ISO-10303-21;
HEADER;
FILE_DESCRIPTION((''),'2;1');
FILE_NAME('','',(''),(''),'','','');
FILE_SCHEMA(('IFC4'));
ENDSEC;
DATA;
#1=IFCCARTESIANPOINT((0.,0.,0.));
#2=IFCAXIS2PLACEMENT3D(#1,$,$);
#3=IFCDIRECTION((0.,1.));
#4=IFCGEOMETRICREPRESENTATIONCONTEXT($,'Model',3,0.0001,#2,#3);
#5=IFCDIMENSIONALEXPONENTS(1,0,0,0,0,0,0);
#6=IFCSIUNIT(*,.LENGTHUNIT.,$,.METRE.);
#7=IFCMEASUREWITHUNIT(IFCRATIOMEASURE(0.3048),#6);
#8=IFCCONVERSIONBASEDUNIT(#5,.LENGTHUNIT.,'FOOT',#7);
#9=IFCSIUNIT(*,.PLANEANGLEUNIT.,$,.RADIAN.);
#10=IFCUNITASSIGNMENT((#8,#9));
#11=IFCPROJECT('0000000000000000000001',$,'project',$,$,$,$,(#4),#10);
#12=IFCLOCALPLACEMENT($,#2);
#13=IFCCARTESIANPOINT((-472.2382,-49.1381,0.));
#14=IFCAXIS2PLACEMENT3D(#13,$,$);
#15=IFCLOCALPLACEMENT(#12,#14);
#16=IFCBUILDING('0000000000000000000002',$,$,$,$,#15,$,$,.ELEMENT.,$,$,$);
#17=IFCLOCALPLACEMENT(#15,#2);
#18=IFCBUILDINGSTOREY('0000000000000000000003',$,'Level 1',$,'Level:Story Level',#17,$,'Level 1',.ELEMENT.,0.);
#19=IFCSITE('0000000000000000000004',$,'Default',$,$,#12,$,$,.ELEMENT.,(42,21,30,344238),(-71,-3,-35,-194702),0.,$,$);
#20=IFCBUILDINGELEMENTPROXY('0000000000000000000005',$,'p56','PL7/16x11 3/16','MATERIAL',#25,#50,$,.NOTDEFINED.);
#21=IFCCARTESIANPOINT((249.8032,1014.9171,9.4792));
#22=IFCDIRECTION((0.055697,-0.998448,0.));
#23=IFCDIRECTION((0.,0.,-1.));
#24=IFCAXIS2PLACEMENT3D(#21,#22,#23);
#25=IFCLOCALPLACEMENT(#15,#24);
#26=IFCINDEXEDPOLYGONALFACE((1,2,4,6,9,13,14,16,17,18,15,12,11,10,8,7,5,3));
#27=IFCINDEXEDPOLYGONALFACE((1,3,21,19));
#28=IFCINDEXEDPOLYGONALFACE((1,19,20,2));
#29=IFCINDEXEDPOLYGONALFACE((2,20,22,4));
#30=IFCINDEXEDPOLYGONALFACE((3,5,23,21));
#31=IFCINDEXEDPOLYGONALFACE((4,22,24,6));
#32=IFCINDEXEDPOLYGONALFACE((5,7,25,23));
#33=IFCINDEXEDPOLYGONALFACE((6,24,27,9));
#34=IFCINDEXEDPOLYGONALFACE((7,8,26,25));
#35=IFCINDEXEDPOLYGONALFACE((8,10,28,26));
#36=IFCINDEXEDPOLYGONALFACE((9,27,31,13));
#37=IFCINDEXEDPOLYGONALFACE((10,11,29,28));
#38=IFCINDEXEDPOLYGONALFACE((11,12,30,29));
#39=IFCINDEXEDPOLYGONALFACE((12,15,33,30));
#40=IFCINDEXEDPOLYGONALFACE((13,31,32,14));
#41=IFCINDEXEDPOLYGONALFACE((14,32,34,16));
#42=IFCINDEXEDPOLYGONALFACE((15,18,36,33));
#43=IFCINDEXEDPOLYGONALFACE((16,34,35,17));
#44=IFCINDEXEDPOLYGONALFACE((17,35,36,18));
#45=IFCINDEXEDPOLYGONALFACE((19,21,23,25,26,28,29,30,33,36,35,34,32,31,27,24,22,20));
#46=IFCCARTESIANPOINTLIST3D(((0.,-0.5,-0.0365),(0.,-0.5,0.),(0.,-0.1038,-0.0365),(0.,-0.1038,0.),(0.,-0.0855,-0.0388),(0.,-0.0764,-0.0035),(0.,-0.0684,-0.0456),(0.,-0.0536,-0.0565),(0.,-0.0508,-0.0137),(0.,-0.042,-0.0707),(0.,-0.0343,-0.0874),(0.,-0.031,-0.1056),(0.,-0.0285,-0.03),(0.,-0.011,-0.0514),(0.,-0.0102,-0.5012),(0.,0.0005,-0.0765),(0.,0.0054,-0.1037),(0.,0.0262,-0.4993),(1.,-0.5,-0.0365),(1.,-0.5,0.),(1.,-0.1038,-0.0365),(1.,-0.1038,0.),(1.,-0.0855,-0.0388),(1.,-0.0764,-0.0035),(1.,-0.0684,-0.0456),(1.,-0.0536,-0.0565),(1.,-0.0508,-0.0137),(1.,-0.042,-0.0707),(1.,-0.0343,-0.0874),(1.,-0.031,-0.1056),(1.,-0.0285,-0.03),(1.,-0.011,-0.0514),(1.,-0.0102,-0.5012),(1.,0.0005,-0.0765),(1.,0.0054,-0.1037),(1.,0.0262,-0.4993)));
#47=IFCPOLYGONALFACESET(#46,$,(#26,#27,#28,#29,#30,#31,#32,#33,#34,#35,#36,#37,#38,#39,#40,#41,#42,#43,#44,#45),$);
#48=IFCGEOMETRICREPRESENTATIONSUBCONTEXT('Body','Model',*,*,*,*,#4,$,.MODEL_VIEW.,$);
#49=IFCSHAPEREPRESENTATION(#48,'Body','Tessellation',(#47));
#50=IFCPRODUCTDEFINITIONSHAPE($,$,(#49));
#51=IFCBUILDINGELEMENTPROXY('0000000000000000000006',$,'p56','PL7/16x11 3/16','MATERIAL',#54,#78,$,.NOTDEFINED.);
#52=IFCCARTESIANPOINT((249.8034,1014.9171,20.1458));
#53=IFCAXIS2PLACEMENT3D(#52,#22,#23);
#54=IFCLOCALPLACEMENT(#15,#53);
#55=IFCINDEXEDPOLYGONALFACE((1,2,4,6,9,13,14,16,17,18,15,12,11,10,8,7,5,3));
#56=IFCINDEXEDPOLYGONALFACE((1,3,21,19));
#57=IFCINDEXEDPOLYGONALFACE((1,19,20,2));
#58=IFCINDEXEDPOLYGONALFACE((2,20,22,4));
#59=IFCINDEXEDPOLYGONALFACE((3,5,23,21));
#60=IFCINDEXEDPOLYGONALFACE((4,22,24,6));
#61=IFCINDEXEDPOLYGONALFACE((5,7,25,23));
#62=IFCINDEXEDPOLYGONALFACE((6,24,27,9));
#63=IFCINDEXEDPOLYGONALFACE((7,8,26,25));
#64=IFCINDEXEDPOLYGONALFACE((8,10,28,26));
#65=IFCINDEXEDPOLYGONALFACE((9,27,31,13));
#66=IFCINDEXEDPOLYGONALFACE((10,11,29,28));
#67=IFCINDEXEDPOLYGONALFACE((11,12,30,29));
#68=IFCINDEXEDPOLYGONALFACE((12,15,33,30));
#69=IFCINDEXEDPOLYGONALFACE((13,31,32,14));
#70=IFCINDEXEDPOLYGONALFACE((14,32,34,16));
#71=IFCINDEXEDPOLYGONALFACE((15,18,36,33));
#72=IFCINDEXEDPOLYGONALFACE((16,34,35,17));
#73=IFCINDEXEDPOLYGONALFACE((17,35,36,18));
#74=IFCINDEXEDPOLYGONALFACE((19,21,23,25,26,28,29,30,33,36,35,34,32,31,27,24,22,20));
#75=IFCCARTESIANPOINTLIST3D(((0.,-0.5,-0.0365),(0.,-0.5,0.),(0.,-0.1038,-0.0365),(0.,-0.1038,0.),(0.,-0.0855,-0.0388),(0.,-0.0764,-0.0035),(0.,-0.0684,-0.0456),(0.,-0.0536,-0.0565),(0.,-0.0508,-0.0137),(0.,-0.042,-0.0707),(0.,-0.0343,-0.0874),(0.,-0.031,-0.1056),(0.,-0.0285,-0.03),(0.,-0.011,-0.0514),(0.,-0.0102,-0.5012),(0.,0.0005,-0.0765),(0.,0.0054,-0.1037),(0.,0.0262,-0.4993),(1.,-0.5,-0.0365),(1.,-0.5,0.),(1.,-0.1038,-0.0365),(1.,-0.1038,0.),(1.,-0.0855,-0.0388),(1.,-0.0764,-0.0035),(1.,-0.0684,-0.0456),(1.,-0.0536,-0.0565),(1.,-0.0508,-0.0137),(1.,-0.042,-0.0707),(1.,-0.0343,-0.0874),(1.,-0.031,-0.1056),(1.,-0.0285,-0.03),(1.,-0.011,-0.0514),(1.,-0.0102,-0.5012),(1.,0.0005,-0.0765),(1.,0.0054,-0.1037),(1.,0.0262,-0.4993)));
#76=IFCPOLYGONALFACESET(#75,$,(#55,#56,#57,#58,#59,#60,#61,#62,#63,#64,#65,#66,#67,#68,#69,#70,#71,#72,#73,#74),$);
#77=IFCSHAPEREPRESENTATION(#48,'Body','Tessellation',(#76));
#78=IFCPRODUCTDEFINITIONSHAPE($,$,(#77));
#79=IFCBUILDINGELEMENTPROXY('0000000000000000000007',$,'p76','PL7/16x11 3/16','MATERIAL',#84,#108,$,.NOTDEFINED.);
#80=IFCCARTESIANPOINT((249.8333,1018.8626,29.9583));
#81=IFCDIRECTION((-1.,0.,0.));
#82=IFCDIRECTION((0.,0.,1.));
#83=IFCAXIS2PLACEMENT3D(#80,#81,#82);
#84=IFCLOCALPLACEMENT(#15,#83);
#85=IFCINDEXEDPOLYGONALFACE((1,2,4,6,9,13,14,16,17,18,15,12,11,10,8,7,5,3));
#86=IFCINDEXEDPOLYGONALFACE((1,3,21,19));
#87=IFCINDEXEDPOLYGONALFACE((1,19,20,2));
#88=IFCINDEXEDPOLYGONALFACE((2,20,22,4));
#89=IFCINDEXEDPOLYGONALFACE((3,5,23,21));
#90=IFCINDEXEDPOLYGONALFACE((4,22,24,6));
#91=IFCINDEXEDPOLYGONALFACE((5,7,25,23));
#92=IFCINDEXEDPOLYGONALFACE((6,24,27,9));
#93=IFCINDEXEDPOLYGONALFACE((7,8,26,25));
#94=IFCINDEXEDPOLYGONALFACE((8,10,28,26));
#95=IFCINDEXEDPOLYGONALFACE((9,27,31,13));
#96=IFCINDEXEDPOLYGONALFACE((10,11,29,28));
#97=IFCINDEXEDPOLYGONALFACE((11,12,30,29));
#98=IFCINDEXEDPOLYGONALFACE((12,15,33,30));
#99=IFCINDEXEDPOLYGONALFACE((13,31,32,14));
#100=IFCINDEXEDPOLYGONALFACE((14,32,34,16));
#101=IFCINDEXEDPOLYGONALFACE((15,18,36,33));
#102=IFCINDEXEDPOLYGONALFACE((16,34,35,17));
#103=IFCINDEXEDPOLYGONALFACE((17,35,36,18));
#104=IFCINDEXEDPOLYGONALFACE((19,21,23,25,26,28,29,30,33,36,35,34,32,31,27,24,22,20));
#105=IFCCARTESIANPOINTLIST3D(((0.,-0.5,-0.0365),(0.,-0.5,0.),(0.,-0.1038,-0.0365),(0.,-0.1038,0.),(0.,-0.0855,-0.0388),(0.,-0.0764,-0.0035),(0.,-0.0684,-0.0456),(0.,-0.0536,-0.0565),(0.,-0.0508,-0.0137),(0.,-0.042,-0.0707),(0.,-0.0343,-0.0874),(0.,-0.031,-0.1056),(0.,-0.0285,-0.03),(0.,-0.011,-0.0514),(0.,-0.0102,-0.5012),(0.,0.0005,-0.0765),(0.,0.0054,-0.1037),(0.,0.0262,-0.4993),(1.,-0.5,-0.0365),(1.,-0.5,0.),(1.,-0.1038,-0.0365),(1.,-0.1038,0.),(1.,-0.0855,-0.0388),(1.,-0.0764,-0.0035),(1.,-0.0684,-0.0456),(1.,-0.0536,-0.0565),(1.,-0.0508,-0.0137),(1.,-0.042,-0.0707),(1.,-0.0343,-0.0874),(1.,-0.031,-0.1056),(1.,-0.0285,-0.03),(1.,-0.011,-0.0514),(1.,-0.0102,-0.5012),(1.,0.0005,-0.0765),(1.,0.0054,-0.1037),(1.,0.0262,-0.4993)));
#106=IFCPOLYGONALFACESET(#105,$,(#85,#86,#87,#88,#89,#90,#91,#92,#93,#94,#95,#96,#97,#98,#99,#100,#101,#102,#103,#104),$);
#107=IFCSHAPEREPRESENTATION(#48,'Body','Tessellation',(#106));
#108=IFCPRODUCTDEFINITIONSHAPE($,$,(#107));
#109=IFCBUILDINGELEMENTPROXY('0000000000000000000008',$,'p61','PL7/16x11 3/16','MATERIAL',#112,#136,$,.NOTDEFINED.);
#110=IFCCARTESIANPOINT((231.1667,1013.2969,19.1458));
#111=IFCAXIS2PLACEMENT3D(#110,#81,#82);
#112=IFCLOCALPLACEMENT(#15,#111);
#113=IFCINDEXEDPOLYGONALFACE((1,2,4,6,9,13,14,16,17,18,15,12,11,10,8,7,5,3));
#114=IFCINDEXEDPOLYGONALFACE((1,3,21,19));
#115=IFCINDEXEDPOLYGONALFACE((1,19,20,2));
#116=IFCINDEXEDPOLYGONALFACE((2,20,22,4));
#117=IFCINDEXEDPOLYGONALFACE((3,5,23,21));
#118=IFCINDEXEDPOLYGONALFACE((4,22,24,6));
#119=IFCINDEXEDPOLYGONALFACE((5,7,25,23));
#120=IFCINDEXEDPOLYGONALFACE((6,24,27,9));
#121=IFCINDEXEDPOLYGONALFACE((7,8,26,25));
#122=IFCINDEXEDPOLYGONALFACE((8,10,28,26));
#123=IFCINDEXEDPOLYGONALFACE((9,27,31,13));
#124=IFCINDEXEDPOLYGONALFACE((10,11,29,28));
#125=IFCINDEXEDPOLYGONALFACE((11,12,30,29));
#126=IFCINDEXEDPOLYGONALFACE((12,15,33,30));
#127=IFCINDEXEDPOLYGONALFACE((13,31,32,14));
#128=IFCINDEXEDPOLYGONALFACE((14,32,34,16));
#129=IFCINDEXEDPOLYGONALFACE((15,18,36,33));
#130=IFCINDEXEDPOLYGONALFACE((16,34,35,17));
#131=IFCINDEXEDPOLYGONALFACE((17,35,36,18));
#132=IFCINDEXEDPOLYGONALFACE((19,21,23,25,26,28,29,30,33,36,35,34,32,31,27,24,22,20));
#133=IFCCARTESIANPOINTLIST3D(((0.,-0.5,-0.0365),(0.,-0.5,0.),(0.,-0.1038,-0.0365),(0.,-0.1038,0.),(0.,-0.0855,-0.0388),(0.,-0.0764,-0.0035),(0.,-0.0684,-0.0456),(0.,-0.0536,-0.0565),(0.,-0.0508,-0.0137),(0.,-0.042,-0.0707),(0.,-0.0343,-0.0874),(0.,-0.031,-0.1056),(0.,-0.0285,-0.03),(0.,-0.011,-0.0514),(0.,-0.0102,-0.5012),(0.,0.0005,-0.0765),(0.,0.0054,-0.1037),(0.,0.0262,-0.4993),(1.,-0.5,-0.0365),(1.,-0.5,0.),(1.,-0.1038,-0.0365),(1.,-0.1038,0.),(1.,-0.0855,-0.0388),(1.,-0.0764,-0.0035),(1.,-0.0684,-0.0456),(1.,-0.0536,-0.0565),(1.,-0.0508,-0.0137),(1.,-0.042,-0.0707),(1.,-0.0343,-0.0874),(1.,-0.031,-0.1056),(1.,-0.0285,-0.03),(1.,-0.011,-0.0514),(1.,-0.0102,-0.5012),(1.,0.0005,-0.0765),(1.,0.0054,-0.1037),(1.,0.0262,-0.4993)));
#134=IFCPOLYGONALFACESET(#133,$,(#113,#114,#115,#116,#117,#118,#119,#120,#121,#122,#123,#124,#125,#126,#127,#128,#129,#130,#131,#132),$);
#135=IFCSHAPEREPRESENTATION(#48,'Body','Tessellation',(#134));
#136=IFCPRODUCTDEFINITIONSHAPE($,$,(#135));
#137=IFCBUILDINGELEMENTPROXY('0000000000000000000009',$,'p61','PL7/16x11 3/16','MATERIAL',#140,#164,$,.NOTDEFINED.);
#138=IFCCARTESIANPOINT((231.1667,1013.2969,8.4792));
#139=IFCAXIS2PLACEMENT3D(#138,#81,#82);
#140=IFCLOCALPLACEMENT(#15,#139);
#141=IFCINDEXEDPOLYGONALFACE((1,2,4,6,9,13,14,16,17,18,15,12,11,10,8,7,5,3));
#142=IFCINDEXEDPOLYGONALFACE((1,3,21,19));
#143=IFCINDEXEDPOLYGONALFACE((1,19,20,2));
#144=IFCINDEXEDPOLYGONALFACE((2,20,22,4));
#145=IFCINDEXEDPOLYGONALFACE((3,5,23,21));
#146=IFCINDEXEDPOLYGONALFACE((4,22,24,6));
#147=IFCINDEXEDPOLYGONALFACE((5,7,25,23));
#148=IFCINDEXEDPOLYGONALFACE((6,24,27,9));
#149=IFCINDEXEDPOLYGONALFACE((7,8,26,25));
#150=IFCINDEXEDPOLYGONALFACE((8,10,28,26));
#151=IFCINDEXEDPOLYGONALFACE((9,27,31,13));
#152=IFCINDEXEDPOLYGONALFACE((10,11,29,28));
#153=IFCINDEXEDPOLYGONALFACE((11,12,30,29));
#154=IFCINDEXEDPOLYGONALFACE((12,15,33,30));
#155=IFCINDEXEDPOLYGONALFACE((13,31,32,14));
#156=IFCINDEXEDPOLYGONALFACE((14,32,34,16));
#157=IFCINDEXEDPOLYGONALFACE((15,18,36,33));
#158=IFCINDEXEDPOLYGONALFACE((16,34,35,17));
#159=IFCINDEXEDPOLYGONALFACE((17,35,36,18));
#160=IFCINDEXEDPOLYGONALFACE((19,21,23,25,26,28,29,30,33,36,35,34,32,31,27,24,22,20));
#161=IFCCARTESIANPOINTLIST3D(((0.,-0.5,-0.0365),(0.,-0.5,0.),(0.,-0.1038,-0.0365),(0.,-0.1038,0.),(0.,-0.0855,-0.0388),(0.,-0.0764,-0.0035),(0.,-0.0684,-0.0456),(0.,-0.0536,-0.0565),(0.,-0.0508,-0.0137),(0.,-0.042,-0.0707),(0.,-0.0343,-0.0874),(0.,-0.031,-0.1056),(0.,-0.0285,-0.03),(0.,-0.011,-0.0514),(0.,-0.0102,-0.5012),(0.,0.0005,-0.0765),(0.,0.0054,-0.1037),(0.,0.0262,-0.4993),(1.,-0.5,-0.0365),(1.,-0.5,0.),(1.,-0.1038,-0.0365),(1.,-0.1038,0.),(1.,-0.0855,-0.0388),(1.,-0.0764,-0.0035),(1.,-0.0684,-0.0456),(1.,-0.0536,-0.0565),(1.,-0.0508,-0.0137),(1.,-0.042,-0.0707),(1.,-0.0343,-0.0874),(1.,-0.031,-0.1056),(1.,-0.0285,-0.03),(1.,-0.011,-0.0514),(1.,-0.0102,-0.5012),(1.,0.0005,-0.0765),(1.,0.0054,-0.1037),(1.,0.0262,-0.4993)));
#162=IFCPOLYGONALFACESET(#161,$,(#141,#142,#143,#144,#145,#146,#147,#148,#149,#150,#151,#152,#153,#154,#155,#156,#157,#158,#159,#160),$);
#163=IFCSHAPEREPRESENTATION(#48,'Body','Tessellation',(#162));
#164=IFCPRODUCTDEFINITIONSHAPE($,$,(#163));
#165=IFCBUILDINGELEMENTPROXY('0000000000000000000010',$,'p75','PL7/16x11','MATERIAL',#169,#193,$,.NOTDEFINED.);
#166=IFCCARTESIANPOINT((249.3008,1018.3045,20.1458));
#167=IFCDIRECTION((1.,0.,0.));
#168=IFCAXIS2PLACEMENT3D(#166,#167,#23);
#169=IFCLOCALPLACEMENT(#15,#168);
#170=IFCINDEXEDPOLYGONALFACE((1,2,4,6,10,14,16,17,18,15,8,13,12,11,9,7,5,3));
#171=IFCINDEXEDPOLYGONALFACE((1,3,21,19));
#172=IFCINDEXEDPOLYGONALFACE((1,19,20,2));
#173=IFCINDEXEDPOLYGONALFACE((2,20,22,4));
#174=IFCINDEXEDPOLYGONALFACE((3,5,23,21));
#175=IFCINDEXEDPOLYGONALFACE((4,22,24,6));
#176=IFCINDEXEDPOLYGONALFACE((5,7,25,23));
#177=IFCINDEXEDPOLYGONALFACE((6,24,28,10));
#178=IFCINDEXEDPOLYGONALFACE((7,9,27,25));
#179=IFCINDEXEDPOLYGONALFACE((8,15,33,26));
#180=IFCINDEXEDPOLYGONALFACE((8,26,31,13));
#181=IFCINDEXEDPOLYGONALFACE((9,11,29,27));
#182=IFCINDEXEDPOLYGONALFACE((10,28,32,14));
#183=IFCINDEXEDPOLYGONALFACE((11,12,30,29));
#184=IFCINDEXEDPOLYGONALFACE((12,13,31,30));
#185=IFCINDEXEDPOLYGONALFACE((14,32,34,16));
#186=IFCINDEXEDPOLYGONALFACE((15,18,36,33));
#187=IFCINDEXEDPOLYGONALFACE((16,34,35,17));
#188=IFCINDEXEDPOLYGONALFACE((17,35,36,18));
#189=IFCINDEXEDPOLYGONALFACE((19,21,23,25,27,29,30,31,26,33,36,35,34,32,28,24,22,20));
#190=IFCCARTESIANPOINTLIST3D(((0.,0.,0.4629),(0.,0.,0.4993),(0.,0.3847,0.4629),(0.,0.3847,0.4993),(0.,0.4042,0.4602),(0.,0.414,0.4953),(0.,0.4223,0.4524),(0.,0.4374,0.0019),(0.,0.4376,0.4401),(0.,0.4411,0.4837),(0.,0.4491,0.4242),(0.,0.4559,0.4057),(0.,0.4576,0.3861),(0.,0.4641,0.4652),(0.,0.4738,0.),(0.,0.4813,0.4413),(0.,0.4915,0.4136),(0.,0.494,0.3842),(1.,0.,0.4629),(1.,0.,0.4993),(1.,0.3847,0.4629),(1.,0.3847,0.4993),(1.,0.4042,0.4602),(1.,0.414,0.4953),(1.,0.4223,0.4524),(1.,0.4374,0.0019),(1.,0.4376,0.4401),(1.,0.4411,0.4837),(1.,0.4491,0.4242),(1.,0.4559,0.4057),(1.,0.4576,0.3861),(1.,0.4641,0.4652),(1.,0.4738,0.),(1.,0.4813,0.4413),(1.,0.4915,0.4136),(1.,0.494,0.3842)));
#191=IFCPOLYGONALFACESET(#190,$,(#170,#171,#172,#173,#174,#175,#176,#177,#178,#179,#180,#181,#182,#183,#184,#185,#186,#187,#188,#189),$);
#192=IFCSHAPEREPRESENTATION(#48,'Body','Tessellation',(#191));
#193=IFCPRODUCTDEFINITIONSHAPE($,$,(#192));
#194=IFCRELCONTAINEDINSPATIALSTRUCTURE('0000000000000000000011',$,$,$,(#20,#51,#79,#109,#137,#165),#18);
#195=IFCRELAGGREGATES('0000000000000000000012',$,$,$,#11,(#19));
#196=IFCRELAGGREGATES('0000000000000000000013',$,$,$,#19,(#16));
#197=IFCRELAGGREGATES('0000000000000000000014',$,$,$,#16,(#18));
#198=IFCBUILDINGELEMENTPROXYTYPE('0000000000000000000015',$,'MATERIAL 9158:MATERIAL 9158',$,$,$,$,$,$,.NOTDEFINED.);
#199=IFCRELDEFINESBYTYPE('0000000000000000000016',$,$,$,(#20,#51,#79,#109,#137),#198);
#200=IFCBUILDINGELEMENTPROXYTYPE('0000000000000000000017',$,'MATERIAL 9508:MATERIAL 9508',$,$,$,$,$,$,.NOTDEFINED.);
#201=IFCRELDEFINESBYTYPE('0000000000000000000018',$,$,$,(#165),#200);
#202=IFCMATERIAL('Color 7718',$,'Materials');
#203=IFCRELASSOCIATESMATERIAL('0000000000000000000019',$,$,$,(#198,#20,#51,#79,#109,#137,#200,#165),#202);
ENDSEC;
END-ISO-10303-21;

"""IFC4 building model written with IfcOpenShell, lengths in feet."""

from ifc_helpers import new_model, entity, si_unit, converted_unit, direction, frame, origin, place, context, subcontext, project, spatial, polyline, outline, extrude, source, transform, mapped, material, type_object, type_shapes, element, save


model = new_model("IFC4")

# Units and contexts
model_context = context("Model", 3, precision=0.0001, world=origin(), true_north=direction((0.0, 1.0)))
body_context = subcontext(model_context, "Body", "Model", "MODEL_VIEW")
ifc_project = project(units=[converted_unit("LENGTHUNIT", "FOOT", entity("IfcRatioMeasure", 0.3048), si_unit("LENGTHUNIT", "METRE"), dimensions=[1, 0, 0, 0, 0, 0, 0]), si_unit("PLANEANGLEUNIT", "RADIAN")], contexts=[model_context])

# Site, building, storey
site_placement = place(None, origin())
site = spatial("IfcSite", under=ifc_project, at=site_placement, Name="Default", CompositionType="ELEMENT", RefLatitude=(42, 21, 30, 344238), RefLongitude=(-71, -3, -35, -194702), RefElevation=0.0)
building_placement = place(site_placement, frame((-472.2382, -49.1381, 0.0)))
building = spatial("IfcBuilding", under=site, at=building_placement, CompositionType="ELEMENT")
storey_placement = place(building_placement, origin())
storey = spatial("IfcBuildingStorey", under=building, at=storey_placement, Name="Level 1", ObjectType="Level:Story Level", LongName="Level 1", CompositionType="ELEMENT", Elevation=0.0)

# Building element proxies
ifc_material_1 = material(Name="Color 7718", Category="Materials")
building_element_proxy_type_1 = type_object("IfcBuildingElementProxyType", Name="MATERIAL 9158:MATERIAL 9158", PredefinedType="NOTDEFINED", material=ifc_material_1)
shared_shape_1 = source(origin(), body_context, "Body", "SweptSolid", [
    extrude(outline(polyline([(0.0112, -0.0976), (0.4074, -0.0976), (0.4074, -0.0611), (0.0112, -0.0611), (-0.0071, -0.0588), (-0.0242, -0.052), (-0.039, -0.0411), (-0.0507, -0.0269), (-0.0584, -0.0102), (-0.0616, 0.008), (-0.0824, 0.4036), (-0.1188, 0.4017), (-0.0981, 0.006), (-0.0931, -0.0211), (-0.0816, -0.0462), (-0.0641, -0.0676), (-0.0419, -0.0839), (-0.0162, -0.0941), (0.0112, -0.0976)])), frame((0.0, -0.0926, -0.0976), z_axis=(1.0, 0.0, 0.0), x_axis=(0.0, -1.0, 0.0)), (0.0, 0.0, 1.0), 1.0),
])
type_shapes(building_element_proxy_type_1, [shared_shape_1])
for number, where, z_axis, x_axis, name in (
    (1, (249.8032, 1014.9171, 9.4792), (0.055697, -0.998448, 0.0), (0.0, 0.0, -1.0), "p56"),
    (2, (249.8034, 1014.9171, 20.1458), (0.055697, -0.998448, 0.0), (0.0, 0.0, -1.0), "p56"),
    (3, (249.8333, 1018.8626, 29.9583), (-1.0, 0.0, 0.0), (0.0, 0.0, 1.0), "p76"),
    (4, (231.1667, 1013.2969, 19.1458), (-1.0, 0.0, 0.0), (0.0, 0.0, 1.0), "p61"),
    (5, (231.1667, 1013.2969, 8.4792), (-1.0, 0.0, 0.0), (0.0, 0.0, 1.0), "p61"),
):
    element("IfcBuildingElementProxy", number, at=place(building_placement, frame(where, z_axis=z_axis, x_axis=x_axis)), inside=storey, type_object=building_element_proxy_type_1, material=ifc_material_1, Name=name, Description="PL7/16x11 3/16", ObjectType="MATERIAL", PredefinedType="NOTDEFINED", context=body_context, shape_type="MappedRepresentation", body=[
        mapped(shared_shape_1, transform((0.0, 0.0, 0.0), scale=1.0)),
    ])
building_element_proxy_type_2 = type_object("IfcBuildingElementProxyType", Name="MATERIAL 9508:MATERIAL 9508", PredefinedType="NOTDEFINED", material=ifc_material_1)
shared_shape_2 = source(origin(), body_context, "Body", "SweptSolid", [
    extrude(outline(polyline([(0.0093, -0.1005), (0.3941, -0.1005), (0.3941, -0.0641), (0.0093, -0.0641), (-0.0101, -0.0614), (-0.0282, -0.0536), (-0.0436, -0.0413), (-0.055, -0.0254), (-0.0619, -0.0069), (-0.0635, 0.0127), (-0.0433, 0.3969), (-0.0798, 0.3988), (-0.0999, 0.0146), (-0.0974, -0.0148), (-0.0872, -0.0425), (-0.07, -0.0664), (-0.047, -0.0849), (-0.0199, -0.0965), (0.0093, -0.1005)])), frame((0.0, 0.3941, 0.3988), z_axis=(1.0, 0.0, 0.0), x_axis=(0.0, -1.0, 0.0)), (0.0, 0.0, 1.0), 1.0),
])
type_shapes(building_element_proxy_type_2, [shared_shape_2])
for number, where, z_axis, x_axis, name in (
    (6, (249.3008, 1018.3045, 20.1458), (1.0, 0.0, 0.0), (0.0, 0.0, -1.0), "p75"),
):
    element("IfcBuildingElementProxy", number, at=place(building_placement, frame(where, z_axis=z_axis, x_axis=x_axis)), inside=storey, type_object=building_element_proxy_type_2, material=ifc_material_1, Name=name, Description="PL7/16x11", ObjectType="MATERIAL", PredefinedType="NOTDEFINED", context=body_context, shape_type="MappedRepresentation", body=[
        mapped(shared_shape_2, transform((0.0, 0.0, 0.0), scale=1.0)),
    ])

save(model, "model.ifc")
